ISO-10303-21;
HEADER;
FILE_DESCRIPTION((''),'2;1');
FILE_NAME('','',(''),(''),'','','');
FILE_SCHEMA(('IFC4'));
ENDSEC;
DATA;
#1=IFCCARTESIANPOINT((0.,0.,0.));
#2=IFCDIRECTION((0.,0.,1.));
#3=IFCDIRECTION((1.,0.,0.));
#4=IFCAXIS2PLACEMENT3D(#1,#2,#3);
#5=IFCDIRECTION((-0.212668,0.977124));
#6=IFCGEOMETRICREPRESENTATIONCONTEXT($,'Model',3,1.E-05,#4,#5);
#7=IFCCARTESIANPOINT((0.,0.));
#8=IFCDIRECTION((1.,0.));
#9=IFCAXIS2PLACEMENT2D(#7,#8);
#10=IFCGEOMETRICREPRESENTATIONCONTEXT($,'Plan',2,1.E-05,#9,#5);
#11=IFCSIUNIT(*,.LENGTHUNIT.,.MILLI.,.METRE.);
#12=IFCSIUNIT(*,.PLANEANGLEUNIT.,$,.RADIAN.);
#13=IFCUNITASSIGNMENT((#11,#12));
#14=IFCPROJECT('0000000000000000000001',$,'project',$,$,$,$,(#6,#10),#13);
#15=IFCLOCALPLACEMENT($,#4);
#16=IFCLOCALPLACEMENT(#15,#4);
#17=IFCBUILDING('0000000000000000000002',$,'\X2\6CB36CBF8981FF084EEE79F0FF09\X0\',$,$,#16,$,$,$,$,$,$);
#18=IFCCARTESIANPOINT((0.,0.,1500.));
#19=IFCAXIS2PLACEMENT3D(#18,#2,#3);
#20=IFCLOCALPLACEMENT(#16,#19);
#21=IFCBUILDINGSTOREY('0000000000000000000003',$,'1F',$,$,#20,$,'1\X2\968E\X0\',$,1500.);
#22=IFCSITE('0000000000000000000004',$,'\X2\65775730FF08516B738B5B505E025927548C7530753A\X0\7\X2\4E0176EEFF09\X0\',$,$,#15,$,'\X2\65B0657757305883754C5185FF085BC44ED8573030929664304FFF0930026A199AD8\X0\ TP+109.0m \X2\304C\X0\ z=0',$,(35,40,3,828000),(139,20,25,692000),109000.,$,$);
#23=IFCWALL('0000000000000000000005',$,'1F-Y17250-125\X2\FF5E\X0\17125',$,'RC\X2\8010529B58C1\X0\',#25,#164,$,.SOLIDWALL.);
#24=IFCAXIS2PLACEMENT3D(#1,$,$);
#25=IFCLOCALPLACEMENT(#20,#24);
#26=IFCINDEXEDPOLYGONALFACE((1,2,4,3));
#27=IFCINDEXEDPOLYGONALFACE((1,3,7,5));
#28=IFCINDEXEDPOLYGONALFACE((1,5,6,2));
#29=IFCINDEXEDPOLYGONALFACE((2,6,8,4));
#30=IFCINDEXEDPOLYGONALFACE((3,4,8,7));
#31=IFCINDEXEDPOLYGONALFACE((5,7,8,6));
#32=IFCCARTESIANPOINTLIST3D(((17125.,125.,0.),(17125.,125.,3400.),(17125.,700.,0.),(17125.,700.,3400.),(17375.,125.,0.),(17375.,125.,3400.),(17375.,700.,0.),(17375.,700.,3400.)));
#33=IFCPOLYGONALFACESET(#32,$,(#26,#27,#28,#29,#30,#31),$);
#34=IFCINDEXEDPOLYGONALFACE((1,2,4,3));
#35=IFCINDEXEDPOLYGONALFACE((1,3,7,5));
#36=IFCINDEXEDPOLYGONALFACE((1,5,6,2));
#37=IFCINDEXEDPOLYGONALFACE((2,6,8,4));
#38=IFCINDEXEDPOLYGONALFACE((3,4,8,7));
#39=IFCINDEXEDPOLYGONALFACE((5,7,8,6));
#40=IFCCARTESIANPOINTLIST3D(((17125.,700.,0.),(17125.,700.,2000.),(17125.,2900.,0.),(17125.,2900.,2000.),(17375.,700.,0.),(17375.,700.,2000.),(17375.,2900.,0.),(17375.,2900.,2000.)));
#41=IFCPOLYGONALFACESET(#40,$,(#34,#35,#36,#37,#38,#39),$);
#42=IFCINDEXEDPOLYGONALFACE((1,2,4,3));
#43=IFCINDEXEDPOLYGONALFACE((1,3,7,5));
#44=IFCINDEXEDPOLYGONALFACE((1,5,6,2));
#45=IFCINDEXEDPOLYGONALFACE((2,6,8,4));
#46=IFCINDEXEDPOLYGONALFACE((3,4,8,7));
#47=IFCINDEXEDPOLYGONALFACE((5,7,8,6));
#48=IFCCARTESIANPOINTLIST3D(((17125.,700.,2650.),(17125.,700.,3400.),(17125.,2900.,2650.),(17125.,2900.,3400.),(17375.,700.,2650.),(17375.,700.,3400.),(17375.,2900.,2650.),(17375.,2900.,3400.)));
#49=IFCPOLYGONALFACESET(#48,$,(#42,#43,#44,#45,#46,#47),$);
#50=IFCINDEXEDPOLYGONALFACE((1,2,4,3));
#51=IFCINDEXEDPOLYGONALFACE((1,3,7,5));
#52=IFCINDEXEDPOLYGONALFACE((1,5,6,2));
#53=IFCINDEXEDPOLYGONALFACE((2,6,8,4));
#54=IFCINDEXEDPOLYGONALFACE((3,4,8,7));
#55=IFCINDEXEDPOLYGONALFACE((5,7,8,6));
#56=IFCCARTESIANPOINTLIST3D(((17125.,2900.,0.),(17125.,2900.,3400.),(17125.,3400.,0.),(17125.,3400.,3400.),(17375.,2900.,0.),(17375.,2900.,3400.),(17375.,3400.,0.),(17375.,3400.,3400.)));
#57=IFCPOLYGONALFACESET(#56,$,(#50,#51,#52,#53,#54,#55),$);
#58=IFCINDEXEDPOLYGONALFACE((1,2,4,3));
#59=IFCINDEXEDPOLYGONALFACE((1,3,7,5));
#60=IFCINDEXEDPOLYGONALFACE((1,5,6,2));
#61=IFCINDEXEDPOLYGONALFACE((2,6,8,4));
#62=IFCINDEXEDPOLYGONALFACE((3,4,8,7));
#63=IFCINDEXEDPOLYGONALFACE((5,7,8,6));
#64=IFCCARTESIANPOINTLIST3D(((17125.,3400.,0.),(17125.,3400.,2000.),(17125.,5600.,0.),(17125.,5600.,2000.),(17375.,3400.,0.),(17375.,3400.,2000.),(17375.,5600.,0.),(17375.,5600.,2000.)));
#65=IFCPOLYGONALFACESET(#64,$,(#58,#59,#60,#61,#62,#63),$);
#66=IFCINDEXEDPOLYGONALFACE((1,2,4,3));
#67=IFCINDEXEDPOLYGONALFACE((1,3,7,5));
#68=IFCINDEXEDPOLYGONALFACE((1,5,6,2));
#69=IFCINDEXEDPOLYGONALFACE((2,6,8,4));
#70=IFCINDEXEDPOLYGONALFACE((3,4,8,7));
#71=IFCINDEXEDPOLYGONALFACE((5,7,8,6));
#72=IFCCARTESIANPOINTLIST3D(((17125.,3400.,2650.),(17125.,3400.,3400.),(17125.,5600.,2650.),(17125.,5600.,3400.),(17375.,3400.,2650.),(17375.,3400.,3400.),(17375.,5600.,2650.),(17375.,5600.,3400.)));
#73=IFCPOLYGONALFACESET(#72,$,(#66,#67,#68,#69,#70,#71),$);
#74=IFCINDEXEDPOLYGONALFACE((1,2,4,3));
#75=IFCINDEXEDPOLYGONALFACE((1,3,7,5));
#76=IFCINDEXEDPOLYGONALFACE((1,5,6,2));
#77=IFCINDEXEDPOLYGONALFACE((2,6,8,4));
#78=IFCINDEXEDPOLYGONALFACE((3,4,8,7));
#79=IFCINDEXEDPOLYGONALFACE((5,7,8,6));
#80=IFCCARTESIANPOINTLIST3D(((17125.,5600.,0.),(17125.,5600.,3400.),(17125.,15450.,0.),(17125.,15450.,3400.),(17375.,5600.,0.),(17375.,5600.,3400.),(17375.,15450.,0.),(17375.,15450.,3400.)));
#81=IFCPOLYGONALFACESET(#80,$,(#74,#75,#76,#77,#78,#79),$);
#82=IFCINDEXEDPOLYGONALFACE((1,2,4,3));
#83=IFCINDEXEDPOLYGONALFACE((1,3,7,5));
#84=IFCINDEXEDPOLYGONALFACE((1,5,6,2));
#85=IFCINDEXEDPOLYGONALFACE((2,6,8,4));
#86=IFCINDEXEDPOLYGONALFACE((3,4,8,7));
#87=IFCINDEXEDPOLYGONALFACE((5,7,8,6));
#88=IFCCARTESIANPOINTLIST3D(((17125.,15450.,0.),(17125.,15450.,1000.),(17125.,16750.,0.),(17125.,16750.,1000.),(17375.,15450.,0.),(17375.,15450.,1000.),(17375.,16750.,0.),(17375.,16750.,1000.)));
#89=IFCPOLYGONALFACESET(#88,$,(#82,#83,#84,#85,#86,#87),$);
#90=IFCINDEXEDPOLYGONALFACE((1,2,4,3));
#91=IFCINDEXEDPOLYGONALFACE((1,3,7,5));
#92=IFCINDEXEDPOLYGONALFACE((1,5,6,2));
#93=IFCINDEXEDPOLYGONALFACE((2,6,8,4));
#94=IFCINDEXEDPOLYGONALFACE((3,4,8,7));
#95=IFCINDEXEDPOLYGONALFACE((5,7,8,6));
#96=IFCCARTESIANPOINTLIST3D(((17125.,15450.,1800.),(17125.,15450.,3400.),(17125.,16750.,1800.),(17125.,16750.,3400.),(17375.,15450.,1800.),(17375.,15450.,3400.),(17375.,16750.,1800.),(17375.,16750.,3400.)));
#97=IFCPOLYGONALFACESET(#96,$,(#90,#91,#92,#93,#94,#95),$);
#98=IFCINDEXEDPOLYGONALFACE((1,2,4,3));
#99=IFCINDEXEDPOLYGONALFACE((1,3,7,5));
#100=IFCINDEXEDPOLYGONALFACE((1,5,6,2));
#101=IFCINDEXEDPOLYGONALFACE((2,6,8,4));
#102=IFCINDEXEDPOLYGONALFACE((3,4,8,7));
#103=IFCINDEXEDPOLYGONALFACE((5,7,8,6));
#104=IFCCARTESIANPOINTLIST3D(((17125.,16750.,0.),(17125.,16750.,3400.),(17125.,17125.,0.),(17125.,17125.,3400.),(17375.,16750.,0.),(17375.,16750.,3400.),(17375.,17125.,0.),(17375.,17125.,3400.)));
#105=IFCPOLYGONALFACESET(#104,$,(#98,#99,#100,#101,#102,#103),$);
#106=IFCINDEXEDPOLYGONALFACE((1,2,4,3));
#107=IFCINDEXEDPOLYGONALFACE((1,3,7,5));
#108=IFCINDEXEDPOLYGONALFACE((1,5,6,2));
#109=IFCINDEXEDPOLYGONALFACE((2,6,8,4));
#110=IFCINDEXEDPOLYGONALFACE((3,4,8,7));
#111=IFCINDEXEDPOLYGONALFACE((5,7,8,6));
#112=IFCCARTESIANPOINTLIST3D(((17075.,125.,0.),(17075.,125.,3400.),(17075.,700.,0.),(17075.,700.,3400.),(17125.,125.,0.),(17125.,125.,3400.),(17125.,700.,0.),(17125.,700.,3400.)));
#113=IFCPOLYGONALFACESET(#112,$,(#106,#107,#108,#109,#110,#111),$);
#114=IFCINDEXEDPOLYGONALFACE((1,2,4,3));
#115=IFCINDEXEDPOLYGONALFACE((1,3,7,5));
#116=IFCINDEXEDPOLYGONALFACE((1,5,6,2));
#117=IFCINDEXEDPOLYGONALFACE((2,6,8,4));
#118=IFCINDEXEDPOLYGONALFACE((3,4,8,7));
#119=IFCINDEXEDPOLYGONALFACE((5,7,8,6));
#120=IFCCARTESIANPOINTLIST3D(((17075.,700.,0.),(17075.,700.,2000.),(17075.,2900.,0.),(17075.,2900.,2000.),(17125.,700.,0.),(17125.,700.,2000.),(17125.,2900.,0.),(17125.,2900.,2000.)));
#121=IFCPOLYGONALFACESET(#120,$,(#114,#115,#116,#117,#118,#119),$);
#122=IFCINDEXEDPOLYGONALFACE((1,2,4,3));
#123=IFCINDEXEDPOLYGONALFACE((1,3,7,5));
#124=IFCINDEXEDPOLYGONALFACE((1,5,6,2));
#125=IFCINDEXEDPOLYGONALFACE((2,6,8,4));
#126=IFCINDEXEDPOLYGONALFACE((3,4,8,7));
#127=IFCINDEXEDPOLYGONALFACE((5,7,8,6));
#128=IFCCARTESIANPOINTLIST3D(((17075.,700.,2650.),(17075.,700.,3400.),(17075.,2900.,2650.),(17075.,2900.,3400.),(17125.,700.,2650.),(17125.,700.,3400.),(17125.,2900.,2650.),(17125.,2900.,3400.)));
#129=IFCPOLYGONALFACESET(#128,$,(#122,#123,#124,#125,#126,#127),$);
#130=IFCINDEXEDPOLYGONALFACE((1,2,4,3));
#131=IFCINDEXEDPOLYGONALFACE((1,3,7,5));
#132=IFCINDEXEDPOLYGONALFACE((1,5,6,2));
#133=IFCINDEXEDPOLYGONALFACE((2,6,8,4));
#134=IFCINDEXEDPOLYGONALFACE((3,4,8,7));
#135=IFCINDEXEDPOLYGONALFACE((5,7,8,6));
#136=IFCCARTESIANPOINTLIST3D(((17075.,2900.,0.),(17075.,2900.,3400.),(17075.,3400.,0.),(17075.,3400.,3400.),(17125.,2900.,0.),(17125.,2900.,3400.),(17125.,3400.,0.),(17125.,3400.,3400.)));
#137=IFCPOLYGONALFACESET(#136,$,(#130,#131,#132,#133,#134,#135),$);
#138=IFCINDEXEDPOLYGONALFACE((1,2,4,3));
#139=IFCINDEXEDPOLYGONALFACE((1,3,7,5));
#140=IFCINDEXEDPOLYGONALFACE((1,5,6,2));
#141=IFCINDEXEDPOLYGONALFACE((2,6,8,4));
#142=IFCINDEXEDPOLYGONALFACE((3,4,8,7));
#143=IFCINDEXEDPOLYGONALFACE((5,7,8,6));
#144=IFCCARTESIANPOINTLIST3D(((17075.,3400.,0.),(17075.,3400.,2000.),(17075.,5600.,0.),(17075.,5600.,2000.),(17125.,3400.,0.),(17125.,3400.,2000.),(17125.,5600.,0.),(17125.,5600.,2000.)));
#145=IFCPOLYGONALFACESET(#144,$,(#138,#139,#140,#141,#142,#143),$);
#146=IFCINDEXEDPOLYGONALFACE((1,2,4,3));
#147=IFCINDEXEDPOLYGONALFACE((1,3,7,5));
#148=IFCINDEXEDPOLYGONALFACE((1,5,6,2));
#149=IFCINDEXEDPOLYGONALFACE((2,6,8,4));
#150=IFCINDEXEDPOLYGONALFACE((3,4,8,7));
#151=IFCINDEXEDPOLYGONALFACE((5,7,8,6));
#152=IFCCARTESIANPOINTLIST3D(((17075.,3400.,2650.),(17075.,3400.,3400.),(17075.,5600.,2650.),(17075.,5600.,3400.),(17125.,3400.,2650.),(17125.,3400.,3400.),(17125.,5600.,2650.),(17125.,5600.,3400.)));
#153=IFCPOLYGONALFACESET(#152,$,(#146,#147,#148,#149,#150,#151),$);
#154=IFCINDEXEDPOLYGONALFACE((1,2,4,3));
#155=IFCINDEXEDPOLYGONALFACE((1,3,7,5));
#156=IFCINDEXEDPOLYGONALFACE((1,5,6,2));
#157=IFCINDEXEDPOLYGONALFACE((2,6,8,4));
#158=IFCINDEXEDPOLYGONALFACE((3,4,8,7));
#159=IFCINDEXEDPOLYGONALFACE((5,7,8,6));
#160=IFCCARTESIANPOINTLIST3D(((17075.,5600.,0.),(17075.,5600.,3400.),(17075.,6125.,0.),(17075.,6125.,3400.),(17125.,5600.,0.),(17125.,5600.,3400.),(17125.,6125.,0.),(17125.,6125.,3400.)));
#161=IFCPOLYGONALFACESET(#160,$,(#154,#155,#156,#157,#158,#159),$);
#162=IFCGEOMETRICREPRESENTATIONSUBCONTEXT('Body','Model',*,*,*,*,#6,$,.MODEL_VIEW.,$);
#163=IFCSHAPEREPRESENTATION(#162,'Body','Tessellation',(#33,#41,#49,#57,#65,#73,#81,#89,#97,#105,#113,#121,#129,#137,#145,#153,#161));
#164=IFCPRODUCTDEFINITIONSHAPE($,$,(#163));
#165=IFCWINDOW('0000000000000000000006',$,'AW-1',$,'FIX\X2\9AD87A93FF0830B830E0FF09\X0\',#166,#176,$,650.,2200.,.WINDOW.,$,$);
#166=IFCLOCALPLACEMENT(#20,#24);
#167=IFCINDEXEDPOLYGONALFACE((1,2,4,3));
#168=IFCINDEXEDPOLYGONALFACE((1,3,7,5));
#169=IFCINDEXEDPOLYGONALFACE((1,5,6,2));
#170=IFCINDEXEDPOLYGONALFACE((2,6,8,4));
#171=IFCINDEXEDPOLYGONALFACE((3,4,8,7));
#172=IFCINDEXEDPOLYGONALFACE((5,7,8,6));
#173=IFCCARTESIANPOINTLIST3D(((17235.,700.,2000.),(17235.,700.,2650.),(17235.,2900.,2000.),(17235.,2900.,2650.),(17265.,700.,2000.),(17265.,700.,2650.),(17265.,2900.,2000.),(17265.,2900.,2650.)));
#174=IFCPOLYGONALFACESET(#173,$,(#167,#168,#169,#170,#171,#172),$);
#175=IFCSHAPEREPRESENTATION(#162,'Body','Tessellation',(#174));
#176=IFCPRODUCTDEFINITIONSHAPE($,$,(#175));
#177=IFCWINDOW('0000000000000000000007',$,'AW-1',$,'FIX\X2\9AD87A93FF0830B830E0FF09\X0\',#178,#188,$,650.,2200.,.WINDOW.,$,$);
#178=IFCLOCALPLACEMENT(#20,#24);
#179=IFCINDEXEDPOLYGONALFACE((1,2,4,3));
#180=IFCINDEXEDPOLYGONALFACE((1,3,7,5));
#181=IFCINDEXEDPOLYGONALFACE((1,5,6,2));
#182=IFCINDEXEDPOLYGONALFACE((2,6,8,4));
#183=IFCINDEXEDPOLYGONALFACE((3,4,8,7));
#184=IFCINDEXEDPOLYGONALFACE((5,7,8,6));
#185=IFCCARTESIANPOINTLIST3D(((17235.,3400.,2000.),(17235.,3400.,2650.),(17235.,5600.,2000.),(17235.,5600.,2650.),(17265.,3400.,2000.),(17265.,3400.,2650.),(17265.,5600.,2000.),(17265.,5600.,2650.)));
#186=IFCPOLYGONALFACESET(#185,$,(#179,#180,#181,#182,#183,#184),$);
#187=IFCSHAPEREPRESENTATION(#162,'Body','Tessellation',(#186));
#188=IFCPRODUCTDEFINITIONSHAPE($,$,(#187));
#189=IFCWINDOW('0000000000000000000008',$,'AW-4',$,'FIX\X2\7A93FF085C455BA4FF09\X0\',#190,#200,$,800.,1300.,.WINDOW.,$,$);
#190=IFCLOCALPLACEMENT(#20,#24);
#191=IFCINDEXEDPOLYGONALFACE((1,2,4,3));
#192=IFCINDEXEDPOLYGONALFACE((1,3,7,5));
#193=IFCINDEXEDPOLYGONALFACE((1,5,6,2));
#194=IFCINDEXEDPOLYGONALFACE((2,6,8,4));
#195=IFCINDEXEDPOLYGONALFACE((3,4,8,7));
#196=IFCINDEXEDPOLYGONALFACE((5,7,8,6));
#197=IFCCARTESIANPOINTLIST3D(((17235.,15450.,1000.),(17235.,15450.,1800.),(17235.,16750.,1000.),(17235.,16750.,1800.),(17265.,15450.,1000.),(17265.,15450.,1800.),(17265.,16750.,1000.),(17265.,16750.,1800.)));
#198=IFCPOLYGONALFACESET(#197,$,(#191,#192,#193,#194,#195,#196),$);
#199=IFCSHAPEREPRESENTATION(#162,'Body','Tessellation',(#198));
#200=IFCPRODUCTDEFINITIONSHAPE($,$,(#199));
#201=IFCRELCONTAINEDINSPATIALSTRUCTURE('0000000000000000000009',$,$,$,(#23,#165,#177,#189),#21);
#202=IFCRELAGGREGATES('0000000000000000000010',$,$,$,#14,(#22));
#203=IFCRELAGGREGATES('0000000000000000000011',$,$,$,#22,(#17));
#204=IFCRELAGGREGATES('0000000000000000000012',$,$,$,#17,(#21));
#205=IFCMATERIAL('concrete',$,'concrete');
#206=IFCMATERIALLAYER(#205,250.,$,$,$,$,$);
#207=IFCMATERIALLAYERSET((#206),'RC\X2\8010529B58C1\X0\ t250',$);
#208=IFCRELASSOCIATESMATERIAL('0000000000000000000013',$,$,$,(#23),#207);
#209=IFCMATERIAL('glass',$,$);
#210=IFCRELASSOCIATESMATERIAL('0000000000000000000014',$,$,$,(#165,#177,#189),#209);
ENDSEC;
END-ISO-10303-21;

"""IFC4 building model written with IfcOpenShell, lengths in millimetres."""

from ifc_helpers import new_model, si_unit, direction, frame, frame_2d, origin, origin_with_axes, origin_2d_with_axis, place, context, subcontext, project, spatial, rectangle, extrude, material, layer, layer_set, layer_usage, element, fill, save


model = new_model("IFC4")

# Units and contexts
model_context = context("Model", 3, precision=1e-05, world=origin_with_axes(), true_north=direction((-0.212668, 0.977124)))
plan_context = context("Plan", 2, precision=1e-05, world=origin_2d_with_axis(), true_north=direction((-0.212668, 0.977124)))
body_context = subcontext(model_context, "Body", "Model", "MODEL_VIEW")
ifc_project = project(units=[si_unit("LENGTHUNIT", "METRE", prefix="MILLI"), si_unit("PLANEANGLEUNIT", "RADIAN")], contexts=[model_context, plan_context])

# Site, building, storey
site_placement = place(None, origin_with_axes())
site = spatial("IfcSite", under=ifc_project, at=site_placement, Name="敷地（八王子市大和田町7丁目）", LongName="新敷地境界内（寄付地を除く）。標高 TP+109.0m が z=0", RefLatitude=(35, 40, 3, 828000), RefLongitude=(139, 20, 25, 692000), RefElevation=109000.0)
building_placement = place(site_placement, origin_with_axes())
building = spatial("IfcBuilding", under=site, at=building_placement, Name="河沿要（仮称）")
storey_placement = place(building_placement, frame((0.0, 0.0, 1500.0), z_axis=(0.0, 0.0, 1.0), x_axis=(1.0, 0.0, 0.0)))
storey = spatial("IfcBuildingStorey", under=building, at=storey_placement, Name="1F", LongName="1階", Elevation=1500.0)

# Shared definitions
ifc_material_1 = material(Name="concrete", Category="concrete")
ifc_material_2 = material(Name="glass")

# Wall, openings, windows
ifc_layer_1 = layer(ifc_material_1, 250.0)
ifc_layer_set_1 = layer_set([ifc_layer_1], Name="RC耐力壁 t250")
ifc_layer_usage_1 = layer_usage(ifc_layer_set_1, "AXIS2", "POSITIVE", 0.0)
wall_1_placement = place(storey_placement, origin_with_axes())
wall_1 = element("IfcWall", 1, at=wall_1_placement, inside=storey, material=ifc_layer_usage_1, Name="1F-Y17250-125～17125", ObjectType="RC耐力壁", PredefinedType="SOLIDWALL", context=body_context, shape_type="SweptSolid", body=[
    extrude(rectangle(XDim=250.0, YDim=575.0, at=frame_2d((17250.0, 412.5))), origin(), (0.0, 0.0, 1.0), 3400.0),
    extrude(rectangle(XDim=250.0, YDim=2200.0, at=frame_2d((17250.0, 1800.0))), origin(), (0.0, 0.0, 1.0), 2000.0),
    extrude(rectangle(XDim=250.0, YDim=2200.0, at=frame_2d((17250.0, 1800.0))), frame((0.0, 0.0, 2650.0)), (0.0, 0.0, 1.0), 750.0),
    extrude(rectangle(XDim=250.0, YDim=500.0, at=frame_2d((17250.0, 3150.0))), origin(), (0.0, 0.0, 1.0), 3400.0),
    extrude(rectangle(XDim=250.0, YDim=2200.0, at=frame_2d((17250.0, 4500.0))), origin(), (0.0, 0.0, 1.0), 2000.0),
    extrude(rectangle(XDim=250.0, YDim=2200.0, at=frame_2d((17250.0, 4500.0))), frame((0.0, 0.0, 2650.0)), (0.0, 0.0, 1.0), 750.0),
    extrude(rectangle(XDim=250.0, YDim=9850.0, at=frame_2d((17250.0, 10525.0))), origin(), (0.0, 0.0, 1.0), 3400.0),
    extrude(rectangle(XDim=250.0, YDim=1300.0, at=frame_2d((17250.0, 16100.0))), origin(), (0.0, 0.0, 1.0), 1000.0),
    extrude(rectangle(XDim=250.0, YDim=1300.0, at=frame_2d((17250.0, 16100.0))), frame((0.0, 0.0, 1800.0)), (0.0, 0.0, 1.0), 1600.0),
    extrude(rectangle(XDim=250.0, YDim=375.0, at=frame_2d((17250.0, 16937.5))), origin(), (0.0, 0.0, 1.0), 3400.0),
    extrude(rectangle(XDim=50.0, YDim=575.0, at=frame_2d((17100.0, 412.5))), origin(), (0.0, 0.0, 1.0), 3400.0),
    extrude(rectangle(XDim=50.0, YDim=2200.0, at=frame_2d((17100.0, 1800.0))), origin(), (0.0, 0.0, 1.0), 2000.0),
    extrude(rectangle(XDim=50.0, YDim=2200.0, at=frame_2d((17100.0, 1800.0))), frame((0.0, 0.0, 2650.0)), (0.0, 0.0, 1.0), 750.0),
    extrude(rectangle(XDim=50.0, YDim=500.0, at=frame_2d((17100.0, 3150.0))), origin(), (0.0, 0.0, 1.0), 3400.0),
    extrude(rectangle(XDim=50.0, YDim=2200.0, at=frame_2d((17100.0, 4500.0))), origin(), (0.0, 0.0, 1.0), 2000.0),
    extrude(rectangle(XDim=50.0, YDim=2200.0, at=frame_2d((17100.0, 4500.0))), frame((0.0, 0.0, 2650.0)), (0.0, 0.0, 1.0), 750.0),
    extrude(rectangle(XDim=50.0, YDim=525.0, at=frame_2d((17100.0, 5862.5))), origin(), (0.0, 0.0, 1.0), 3400.0),
])
opening_1_placement = place(storey_placement, origin_with_axes())
opening_1 = element("IfcOpeningElement", 2, at=opening_1_placement, inside=storey, cuts=wall_1, PredefinedType="OPENING", context=body_context, shape_type="SweptSolid", body=[
    extrude(rectangle(XDim=300.0, YDim=2200.0, at=frame_2d((17250.0, 1800.0))), frame((0.0, 0.0, 2000.0)), (0.0, 0.0, 1.0), 650.0),
])
opening_2_placement = place(storey_placement, origin_with_axes())
opening_2 = element("IfcOpeningElement", 3, at=opening_2_placement, inside=storey, cuts=wall_1, PredefinedType="OPENING", context=body_context, shape_type="SweptSolid", body=[
    extrude(rectangle(XDim=300.0, YDim=2200.0, at=frame_2d((17250.0, 4500.0))), frame((0.0, 0.0, 2000.0)), (0.0, 0.0, 1.0), 650.0),
])
opening_3_placement = place(storey_placement, origin_with_axes())
opening_3 = element("IfcOpeningElement", 4, at=opening_3_placement, inside=storey, cuts=wall_1, PredefinedType="OPENING", context=body_context, shape_type="SweptSolid", body=[
    extrude(rectangle(XDim=300.0, YDim=1300.0, at=frame_2d((17250.0, 16100.0))), frame((0.0, 0.0, 1000.0)), (0.0, 0.0, 1.0), 800.0),
])
window_1_placement = place(storey_placement, origin_with_axes())
window_1 = element("IfcWindow", 5, at=window_1_placement, inside=storey, material=ifc_material_2, Name="AW-1", ObjectType="FIX高窓（ジム）", OverallHeight=650.0, OverallWidth=2200.0, PredefinedType="WINDOW", context=body_context, shape_type="SweptSolid", body=[
    extrude(rectangle(XDim=30.0, YDim=2200.0, at=frame_2d((17250.0, 1800.0))), frame((0.0, 0.0, 2000.0)), (0.0, 0.0, 1.0), 650.0),
])
fill(opening_1, window_1)
window_2_placement = place(storey_placement, origin_with_axes())
window_2 = element("IfcWindow", 6, at=window_2_placement, inside=storey, material=ifc_material_2, Name="AW-1", ObjectType="FIX高窓（ジム）", OverallHeight=650.0, OverallWidth=2200.0, PredefinedType="WINDOW", context=body_context, shape_type="SweptSolid", body=[
    extrude(rectangle(XDim=30.0, YDim=2200.0, at=frame_2d((17250.0, 4500.0))), frame((0.0, 0.0, 2000.0)), (0.0, 0.0, 1.0), 650.0),
])
fill(opening_2, window_2)
window_3_placement = place(storey_placement, origin_with_axes())
window_3 = element("IfcWindow", 7, at=window_3_placement, inside=storey, material=ifc_material_2, Name="AW-4", ObjectType="FIX窓（居室）", OverallHeight=800.0, OverallWidth=1300.0, PredefinedType="WINDOW", context=body_context, shape_type="SweptSolid", body=[
    extrude(rectangle(XDim=30.0, YDim=1300.0, at=frame_2d((17250.0, 16100.0))), frame((0.0, 0.0, 1000.0)), (0.0, 0.0, 1.0), 800.0),
])
fill(opening_3, window_3)

save(model, "model.ifc")
